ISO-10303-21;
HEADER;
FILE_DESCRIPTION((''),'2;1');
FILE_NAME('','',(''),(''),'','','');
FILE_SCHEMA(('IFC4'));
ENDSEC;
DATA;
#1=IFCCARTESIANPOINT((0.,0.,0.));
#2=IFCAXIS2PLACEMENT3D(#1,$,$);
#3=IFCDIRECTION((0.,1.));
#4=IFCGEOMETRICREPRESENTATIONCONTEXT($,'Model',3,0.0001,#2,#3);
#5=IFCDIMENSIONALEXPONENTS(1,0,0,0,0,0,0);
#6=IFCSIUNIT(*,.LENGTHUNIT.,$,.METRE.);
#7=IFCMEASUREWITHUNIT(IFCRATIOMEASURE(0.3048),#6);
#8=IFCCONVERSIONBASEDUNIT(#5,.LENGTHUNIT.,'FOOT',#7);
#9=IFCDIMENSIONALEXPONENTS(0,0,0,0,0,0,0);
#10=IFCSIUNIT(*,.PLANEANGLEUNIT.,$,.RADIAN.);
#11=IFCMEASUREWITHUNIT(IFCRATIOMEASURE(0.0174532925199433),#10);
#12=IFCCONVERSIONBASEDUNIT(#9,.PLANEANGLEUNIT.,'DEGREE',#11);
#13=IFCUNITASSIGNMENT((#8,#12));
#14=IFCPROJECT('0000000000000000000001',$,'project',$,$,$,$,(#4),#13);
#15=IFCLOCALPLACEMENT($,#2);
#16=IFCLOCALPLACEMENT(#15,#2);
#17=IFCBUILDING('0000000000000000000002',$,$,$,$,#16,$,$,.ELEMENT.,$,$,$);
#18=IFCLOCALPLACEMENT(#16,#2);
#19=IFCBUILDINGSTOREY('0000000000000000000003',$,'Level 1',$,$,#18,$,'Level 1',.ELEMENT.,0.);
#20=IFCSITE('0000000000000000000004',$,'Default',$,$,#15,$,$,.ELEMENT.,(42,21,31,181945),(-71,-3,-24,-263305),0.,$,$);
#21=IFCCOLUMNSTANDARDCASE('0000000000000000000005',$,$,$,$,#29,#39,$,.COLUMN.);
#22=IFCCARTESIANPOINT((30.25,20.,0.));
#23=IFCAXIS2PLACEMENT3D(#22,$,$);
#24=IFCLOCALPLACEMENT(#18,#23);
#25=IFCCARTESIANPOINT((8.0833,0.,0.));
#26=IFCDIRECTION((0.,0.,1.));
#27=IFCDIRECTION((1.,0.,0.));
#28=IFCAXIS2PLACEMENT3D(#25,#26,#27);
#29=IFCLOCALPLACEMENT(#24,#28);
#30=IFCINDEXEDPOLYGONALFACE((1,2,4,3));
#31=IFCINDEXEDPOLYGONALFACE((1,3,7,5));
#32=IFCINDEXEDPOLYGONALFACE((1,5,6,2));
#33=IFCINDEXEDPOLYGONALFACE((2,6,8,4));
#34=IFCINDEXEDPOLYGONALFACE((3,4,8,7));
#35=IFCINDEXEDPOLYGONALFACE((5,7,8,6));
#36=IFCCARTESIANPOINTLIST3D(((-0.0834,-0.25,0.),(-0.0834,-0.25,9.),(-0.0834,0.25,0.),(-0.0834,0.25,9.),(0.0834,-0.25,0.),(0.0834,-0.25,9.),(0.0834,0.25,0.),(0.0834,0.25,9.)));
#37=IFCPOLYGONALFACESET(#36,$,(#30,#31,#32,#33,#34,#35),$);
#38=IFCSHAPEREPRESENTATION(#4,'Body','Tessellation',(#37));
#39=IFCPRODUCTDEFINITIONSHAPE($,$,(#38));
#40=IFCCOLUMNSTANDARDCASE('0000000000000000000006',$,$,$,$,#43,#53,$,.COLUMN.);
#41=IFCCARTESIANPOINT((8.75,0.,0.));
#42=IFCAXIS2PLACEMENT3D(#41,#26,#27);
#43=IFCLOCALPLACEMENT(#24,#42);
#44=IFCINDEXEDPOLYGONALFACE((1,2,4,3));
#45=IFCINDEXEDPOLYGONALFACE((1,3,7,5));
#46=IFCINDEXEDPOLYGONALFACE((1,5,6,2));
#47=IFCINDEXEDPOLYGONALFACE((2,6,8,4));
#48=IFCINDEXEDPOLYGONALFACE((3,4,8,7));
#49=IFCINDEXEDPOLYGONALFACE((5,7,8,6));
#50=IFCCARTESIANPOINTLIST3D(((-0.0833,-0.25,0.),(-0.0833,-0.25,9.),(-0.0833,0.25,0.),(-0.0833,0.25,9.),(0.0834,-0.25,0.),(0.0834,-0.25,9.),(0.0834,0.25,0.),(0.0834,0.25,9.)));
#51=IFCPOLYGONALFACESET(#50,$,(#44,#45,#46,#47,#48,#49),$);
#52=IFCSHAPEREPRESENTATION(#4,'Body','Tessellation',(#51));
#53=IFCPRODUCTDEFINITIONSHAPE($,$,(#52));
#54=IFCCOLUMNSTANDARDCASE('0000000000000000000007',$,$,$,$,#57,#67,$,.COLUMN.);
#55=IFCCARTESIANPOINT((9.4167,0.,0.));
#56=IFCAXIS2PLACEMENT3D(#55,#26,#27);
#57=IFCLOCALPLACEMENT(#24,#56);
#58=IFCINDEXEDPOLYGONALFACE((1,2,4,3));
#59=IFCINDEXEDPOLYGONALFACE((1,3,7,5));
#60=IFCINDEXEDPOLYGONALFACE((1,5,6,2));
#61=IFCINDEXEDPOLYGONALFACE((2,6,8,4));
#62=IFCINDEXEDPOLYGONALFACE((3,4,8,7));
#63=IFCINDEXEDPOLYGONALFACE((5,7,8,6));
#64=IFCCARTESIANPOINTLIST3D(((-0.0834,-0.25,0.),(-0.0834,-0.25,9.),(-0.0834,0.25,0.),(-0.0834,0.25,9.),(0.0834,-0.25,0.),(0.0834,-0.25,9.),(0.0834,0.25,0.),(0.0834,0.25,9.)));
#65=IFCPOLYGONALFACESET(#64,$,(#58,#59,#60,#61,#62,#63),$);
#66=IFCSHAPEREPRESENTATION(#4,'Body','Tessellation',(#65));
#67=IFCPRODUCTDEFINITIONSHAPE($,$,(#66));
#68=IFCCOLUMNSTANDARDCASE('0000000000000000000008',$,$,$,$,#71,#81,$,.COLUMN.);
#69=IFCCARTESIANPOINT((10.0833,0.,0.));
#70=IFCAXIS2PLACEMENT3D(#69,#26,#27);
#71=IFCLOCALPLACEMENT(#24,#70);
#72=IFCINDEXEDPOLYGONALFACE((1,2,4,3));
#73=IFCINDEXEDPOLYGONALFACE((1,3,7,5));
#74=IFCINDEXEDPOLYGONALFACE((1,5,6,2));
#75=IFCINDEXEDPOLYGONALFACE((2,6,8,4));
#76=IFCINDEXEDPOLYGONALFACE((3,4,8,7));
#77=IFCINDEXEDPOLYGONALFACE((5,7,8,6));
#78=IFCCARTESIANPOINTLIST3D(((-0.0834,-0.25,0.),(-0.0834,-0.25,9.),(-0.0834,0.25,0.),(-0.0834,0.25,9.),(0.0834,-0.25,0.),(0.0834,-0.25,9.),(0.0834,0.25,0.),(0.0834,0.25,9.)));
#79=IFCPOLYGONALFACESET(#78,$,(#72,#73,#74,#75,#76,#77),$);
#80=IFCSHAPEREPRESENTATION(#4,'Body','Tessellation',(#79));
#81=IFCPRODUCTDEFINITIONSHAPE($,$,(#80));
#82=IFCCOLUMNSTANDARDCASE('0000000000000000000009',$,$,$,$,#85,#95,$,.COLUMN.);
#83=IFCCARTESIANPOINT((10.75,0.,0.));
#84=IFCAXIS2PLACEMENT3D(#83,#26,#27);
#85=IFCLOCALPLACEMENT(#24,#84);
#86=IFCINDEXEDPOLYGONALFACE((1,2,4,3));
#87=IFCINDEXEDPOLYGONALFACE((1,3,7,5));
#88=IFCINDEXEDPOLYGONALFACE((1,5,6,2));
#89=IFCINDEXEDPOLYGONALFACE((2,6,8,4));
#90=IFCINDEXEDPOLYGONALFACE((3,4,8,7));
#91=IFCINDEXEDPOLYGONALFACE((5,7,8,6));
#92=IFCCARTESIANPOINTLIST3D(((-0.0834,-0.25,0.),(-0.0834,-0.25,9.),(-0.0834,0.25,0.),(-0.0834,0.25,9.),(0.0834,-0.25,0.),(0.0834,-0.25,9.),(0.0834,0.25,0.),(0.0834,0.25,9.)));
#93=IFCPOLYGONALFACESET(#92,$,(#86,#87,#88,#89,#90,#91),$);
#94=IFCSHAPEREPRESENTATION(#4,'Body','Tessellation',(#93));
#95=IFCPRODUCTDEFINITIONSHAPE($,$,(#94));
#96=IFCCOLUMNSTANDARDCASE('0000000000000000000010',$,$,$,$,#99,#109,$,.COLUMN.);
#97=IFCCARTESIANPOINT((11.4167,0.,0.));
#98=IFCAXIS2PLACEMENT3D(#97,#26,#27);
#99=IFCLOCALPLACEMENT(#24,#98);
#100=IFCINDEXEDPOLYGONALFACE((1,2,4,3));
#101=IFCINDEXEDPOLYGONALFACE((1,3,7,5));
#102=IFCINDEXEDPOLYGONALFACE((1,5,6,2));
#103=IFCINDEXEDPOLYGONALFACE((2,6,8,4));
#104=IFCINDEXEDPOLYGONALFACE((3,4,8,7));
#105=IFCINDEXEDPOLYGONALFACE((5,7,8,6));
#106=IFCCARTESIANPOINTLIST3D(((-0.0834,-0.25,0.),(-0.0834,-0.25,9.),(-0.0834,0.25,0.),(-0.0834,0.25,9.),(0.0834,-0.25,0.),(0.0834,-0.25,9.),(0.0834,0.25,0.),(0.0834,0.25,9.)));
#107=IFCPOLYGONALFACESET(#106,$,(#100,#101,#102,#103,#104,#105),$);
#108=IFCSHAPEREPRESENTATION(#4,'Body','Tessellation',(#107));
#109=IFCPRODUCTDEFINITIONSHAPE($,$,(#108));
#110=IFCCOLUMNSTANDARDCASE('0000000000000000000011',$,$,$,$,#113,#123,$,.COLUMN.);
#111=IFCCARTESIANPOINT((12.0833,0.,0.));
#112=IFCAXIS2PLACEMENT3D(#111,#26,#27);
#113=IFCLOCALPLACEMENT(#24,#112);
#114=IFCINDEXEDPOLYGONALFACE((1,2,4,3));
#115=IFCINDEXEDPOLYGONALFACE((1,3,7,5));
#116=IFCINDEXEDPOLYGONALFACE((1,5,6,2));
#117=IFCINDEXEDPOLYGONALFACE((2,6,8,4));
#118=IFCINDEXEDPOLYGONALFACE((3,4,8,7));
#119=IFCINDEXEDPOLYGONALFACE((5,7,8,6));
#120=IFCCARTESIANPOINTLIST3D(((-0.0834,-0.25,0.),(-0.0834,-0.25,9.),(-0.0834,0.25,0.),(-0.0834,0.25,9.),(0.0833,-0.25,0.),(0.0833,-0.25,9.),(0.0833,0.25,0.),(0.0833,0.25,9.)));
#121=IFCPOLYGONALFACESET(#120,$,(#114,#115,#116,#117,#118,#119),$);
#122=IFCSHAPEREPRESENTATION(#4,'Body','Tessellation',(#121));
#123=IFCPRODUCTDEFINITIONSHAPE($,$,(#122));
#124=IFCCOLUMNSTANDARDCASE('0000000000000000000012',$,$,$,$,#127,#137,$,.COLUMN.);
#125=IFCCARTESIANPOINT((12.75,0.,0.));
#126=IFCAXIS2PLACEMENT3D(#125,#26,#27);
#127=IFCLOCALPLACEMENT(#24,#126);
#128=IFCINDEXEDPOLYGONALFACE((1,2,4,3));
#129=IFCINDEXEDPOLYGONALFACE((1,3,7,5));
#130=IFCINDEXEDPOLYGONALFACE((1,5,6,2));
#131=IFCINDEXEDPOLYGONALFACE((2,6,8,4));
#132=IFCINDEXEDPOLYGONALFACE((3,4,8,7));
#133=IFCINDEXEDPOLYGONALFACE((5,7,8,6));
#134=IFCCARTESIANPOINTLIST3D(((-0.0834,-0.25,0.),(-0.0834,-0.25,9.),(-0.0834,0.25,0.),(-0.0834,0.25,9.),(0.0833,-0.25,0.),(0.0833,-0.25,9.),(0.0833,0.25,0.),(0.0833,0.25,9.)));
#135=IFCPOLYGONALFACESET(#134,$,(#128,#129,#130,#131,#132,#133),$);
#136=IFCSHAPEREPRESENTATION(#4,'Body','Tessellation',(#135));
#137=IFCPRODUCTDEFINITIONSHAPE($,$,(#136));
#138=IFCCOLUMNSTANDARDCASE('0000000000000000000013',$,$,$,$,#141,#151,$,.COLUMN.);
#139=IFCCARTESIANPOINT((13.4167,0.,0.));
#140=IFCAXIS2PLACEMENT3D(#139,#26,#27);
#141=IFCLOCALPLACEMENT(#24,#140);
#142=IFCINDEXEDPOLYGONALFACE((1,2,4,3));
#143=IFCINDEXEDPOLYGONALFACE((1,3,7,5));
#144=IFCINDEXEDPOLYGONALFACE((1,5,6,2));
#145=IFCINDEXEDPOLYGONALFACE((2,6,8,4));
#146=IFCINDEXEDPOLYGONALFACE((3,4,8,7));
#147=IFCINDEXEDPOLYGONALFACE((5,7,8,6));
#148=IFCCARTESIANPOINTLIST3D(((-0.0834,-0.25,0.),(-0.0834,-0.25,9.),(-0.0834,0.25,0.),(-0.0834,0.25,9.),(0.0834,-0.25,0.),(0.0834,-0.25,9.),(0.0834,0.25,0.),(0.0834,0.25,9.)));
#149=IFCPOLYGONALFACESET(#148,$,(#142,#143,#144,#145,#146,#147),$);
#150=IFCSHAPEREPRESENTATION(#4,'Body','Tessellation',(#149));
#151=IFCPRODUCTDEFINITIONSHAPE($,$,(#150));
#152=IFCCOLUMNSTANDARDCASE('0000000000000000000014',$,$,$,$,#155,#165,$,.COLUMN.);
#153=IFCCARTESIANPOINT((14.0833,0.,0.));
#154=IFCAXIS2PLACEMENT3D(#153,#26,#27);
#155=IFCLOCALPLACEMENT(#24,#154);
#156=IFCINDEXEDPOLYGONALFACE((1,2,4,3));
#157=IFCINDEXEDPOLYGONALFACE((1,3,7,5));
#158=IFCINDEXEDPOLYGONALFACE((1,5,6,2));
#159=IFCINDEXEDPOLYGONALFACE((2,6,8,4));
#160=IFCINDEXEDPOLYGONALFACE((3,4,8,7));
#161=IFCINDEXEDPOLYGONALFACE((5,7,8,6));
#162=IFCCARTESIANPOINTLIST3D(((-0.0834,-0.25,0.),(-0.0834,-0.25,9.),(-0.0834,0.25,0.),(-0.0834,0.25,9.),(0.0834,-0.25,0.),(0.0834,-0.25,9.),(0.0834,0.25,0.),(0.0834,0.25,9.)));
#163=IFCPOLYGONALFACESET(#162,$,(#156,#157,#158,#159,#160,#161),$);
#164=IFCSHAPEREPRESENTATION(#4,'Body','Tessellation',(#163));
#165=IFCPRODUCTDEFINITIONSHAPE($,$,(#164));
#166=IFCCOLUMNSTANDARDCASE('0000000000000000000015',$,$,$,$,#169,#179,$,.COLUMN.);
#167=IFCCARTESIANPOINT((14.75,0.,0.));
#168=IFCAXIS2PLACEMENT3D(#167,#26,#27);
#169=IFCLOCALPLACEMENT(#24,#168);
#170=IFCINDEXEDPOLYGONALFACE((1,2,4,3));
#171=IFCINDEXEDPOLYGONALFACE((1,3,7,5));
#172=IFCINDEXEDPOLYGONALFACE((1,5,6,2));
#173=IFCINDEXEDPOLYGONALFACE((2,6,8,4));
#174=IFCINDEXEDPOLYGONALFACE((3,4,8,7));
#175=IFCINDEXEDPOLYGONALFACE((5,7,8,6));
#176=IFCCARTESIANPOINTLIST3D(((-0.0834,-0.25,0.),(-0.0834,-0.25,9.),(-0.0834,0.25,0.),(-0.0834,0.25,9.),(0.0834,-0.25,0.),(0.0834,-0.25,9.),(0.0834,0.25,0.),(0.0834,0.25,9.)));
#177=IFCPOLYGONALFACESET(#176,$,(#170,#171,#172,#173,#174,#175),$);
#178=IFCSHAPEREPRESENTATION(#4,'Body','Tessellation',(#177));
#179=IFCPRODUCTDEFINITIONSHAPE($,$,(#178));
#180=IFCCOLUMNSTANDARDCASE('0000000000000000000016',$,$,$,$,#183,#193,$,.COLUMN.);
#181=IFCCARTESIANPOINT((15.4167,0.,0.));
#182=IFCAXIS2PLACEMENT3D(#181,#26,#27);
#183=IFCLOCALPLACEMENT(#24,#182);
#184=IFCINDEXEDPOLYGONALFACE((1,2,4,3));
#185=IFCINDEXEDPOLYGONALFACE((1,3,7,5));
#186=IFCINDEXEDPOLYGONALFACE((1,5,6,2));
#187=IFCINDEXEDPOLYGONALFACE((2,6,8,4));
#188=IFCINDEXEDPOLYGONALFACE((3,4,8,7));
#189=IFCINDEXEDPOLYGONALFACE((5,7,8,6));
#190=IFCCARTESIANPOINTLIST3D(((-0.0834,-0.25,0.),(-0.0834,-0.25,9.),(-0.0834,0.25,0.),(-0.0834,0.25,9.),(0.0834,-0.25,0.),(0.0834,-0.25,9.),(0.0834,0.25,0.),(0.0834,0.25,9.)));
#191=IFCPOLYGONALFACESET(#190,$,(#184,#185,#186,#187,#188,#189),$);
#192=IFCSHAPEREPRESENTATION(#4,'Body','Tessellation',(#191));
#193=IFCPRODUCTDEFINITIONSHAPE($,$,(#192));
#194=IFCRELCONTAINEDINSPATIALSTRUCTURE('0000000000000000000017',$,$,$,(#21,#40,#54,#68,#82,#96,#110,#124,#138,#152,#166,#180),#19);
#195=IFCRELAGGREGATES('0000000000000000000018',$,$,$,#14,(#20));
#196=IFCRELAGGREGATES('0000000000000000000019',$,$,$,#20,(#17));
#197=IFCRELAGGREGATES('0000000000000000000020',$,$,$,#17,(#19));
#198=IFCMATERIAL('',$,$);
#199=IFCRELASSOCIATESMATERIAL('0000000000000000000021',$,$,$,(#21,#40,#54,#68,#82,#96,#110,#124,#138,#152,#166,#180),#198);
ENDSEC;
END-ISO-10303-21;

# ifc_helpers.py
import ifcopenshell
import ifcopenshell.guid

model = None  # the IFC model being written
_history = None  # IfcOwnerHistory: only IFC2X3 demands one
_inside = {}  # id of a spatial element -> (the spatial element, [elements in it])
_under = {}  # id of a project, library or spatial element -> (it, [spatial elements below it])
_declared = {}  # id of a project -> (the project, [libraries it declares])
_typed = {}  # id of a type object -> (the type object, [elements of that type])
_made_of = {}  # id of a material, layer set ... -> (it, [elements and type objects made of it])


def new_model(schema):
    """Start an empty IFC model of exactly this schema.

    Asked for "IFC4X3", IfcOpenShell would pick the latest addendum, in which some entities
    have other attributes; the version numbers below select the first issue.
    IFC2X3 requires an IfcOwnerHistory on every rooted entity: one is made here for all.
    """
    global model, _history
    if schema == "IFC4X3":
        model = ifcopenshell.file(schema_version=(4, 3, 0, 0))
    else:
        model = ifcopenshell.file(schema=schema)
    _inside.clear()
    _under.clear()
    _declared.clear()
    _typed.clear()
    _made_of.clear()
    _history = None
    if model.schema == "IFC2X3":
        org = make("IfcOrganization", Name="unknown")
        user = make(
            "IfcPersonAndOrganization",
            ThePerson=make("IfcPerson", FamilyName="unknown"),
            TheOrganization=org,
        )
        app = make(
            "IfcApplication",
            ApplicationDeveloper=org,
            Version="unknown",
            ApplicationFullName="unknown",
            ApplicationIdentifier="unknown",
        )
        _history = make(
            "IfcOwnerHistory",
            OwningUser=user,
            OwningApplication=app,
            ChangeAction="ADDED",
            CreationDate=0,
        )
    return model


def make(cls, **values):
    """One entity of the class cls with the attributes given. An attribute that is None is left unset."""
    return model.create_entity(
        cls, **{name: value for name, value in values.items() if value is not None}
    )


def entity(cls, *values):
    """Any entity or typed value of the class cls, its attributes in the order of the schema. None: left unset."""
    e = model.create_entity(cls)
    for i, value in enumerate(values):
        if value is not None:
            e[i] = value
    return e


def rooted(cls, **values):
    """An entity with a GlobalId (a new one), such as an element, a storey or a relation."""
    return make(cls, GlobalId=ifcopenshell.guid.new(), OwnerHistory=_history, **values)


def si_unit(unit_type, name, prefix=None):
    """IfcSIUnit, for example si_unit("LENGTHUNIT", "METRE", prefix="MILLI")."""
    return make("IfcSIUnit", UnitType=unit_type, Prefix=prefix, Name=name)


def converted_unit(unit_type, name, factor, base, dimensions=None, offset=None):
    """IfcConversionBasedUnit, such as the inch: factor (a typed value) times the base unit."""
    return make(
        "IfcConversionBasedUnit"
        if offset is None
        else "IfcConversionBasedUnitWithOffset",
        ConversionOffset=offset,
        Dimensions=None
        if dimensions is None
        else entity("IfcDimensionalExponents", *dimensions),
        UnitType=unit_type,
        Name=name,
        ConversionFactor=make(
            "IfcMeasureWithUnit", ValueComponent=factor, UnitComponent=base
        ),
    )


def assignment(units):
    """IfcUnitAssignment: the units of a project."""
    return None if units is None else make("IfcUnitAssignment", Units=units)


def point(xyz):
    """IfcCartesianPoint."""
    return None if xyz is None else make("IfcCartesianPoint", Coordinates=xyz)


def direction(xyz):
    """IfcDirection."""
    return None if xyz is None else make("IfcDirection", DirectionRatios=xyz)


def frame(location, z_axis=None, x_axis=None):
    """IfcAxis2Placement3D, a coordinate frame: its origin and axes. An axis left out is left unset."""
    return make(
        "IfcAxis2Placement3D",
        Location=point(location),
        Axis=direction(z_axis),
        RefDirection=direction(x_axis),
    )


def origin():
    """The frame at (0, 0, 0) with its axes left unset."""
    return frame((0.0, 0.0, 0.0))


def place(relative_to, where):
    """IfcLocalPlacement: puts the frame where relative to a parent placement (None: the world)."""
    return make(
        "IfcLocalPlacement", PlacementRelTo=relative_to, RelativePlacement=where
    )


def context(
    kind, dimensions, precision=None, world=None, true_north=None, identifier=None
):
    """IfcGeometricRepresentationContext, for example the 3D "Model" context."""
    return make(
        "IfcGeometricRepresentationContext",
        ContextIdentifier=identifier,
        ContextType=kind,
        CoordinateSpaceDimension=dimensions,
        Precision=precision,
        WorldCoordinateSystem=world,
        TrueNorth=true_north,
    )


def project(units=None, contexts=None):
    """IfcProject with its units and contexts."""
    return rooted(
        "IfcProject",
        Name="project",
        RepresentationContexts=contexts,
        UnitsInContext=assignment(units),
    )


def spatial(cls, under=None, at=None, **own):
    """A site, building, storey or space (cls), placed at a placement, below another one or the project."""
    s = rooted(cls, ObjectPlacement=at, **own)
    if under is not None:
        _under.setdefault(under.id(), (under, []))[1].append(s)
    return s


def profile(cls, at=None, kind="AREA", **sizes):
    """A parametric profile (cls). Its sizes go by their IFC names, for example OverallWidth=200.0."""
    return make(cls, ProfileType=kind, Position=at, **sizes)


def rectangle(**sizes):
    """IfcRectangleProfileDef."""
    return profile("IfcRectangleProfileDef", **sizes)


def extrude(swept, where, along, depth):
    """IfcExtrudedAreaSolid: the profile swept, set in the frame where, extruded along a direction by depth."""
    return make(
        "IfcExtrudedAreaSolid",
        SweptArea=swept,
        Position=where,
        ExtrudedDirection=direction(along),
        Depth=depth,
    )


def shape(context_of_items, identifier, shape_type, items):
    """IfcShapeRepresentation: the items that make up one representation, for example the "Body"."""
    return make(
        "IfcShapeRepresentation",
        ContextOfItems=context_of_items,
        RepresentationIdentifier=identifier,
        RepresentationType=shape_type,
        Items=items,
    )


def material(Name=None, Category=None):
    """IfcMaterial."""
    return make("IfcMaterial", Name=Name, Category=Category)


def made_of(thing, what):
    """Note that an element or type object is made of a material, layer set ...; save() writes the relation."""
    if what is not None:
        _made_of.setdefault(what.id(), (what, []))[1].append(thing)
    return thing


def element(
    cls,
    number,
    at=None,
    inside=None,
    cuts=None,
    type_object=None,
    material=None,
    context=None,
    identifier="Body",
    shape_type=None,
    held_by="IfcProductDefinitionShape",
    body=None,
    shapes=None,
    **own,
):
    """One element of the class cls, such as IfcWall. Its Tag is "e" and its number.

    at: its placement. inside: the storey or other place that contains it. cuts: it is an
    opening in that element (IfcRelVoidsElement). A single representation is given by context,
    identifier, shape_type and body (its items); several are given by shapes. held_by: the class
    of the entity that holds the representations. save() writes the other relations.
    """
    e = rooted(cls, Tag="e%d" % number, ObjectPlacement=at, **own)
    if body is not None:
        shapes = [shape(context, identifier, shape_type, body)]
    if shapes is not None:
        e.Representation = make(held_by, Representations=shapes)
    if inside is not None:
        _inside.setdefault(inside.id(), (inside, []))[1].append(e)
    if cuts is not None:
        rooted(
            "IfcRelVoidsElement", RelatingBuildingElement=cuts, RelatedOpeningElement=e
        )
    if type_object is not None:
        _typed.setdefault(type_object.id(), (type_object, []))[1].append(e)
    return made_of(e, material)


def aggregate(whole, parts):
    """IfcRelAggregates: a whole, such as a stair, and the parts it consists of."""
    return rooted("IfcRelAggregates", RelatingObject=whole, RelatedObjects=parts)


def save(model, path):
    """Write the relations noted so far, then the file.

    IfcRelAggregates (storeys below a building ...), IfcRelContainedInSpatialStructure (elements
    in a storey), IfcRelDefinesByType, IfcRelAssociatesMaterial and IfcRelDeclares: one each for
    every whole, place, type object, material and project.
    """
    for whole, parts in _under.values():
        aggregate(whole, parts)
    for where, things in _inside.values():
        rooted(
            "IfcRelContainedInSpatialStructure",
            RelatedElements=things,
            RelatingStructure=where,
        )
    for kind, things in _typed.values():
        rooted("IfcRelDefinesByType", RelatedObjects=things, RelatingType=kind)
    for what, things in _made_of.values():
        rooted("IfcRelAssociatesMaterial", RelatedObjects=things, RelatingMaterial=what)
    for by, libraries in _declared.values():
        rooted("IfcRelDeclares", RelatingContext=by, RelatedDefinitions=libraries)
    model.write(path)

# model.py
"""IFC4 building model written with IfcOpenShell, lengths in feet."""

from ifc_helpers import new_model, entity, si_unit, converted_unit, direction, frame, origin, place, context, project, spatial, rectangle, extrude, material, element, save


model = new_model("IFC4")

# Units and contexts
model_context = context("Model", 3, precision=0.0001, world=origin(), true_north=direction((0.0, 1.0)))
ifc_project = project(units=[converted_unit("LENGTHUNIT", "FOOT", entity("IfcRatioMeasure", 0.3048), si_unit("LENGTHUNIT", "METRE"), dimensions=[1, 0, 0, 0, 0, 0, 0]), converted_unit("PLANEANGLEUNIT", "DEGREE", entity("IfcRatioMeasure", 0.0174532925199433), si_unit("PLANEANGLEUNIT", "RADIAN"), dimensions=[0, 0, 0, 0, 0, 0, 0])], contexts=[model_context])

# Site, building, storey
site_placement = place(None, origin())
site = spatial("IfcSite", under=ifc_project, at=site_placement, Name="Default", CompositionType="ELEMENT", RefLatitude=(42, 21, 31, 181945), RefLongitude=(-71, -3, -24, -263305), RefElevation=0.0)
building_placement = place(site_placement, origin())
building = spatial("IfcBuilding", under=site, at=building_placement, CompositionType="ELEMENT")
storey_placement = place(building_placement, origin())
storey = spatial("IfcBuildingStorey", under=building, at=storey_placement, Name="Level 1", LongName="Level 1", CompositionType="ELEMENT", Elevation=0.0)

# Columns
ifc_material_1 = material(Name="")
placement_1 = place(storey_placement, frame((30.25, 20.0, 0.0)))
for number, where, z_axis, x_axis in (
    (1, (8.0833, 0.0, 0.0), (0.0, 0.0, 1.0), (1.0, 0.0, 0.0)),
    (2, (8.75, 0.0, 0.0), (0.0, 0.0, 1.0), (1.0, 0.0, 0.0)),
    (3, (9.4167, 0.0, 0.0), (0.0, 0.0, 1.0), (1.0, 0.0, 0.0)),
    (4, (10.0833, 0.0, 0.0), (0.0, 0.0, 1.0), (1.0, 0.0, 0.0)),
    (5, (10.75, 0.0, 0.0), (0.0, 0.0, 1.0), (1.0, 0.0, 0.0)),
    (6, (11.4167, 0.0, 0.0), (0.0, 0.0, 1.0), (1.0, 0.0, 0.0)),
    (7, (12.0833, 0.0, 0.0), (0.0, 0.0, 1.0), (1.0, 0.0, 0.0)),
    (8, (12.75, 0.0, 0.0), (0.0, 0.0, 1.0), (1.0, 0.0, 0.0)),
    (9, (13.4167, 0.0, 0.0), (0.0, 0.0, 1.0), (1.0, 0.0, 0.0)),
    (10, (14.0833, 0.0, 0.0), (0.0, 0.0, 1.0), (1.0, 0.0, 0.0)),
    (11, (14.75, 0.0, 0.0), (0.0, 0.0, 1.0), (1.0, 0.0, 0.0)),
    (12, (15.4167, 0.0, 0.0), (0.0, 0.0, 1.0), (1.0, 0.0, 0.0)),
):
    element("IfcColumnStandardCase", number, at=place(placement_1, frame(where, z_axis=z_axis, x_axis=x_axis)), inside=storey, material=ifc_material_1, PredefinedType="COLUMN", context=model_context, shape_type="SweptSolid", body=[
        extrude(rectangle(XDim=0.1667, YDim=0.5), origin(), (0.0, 0.0, 1.0), 9.0),
    ])

save(model, "model.ifc")
